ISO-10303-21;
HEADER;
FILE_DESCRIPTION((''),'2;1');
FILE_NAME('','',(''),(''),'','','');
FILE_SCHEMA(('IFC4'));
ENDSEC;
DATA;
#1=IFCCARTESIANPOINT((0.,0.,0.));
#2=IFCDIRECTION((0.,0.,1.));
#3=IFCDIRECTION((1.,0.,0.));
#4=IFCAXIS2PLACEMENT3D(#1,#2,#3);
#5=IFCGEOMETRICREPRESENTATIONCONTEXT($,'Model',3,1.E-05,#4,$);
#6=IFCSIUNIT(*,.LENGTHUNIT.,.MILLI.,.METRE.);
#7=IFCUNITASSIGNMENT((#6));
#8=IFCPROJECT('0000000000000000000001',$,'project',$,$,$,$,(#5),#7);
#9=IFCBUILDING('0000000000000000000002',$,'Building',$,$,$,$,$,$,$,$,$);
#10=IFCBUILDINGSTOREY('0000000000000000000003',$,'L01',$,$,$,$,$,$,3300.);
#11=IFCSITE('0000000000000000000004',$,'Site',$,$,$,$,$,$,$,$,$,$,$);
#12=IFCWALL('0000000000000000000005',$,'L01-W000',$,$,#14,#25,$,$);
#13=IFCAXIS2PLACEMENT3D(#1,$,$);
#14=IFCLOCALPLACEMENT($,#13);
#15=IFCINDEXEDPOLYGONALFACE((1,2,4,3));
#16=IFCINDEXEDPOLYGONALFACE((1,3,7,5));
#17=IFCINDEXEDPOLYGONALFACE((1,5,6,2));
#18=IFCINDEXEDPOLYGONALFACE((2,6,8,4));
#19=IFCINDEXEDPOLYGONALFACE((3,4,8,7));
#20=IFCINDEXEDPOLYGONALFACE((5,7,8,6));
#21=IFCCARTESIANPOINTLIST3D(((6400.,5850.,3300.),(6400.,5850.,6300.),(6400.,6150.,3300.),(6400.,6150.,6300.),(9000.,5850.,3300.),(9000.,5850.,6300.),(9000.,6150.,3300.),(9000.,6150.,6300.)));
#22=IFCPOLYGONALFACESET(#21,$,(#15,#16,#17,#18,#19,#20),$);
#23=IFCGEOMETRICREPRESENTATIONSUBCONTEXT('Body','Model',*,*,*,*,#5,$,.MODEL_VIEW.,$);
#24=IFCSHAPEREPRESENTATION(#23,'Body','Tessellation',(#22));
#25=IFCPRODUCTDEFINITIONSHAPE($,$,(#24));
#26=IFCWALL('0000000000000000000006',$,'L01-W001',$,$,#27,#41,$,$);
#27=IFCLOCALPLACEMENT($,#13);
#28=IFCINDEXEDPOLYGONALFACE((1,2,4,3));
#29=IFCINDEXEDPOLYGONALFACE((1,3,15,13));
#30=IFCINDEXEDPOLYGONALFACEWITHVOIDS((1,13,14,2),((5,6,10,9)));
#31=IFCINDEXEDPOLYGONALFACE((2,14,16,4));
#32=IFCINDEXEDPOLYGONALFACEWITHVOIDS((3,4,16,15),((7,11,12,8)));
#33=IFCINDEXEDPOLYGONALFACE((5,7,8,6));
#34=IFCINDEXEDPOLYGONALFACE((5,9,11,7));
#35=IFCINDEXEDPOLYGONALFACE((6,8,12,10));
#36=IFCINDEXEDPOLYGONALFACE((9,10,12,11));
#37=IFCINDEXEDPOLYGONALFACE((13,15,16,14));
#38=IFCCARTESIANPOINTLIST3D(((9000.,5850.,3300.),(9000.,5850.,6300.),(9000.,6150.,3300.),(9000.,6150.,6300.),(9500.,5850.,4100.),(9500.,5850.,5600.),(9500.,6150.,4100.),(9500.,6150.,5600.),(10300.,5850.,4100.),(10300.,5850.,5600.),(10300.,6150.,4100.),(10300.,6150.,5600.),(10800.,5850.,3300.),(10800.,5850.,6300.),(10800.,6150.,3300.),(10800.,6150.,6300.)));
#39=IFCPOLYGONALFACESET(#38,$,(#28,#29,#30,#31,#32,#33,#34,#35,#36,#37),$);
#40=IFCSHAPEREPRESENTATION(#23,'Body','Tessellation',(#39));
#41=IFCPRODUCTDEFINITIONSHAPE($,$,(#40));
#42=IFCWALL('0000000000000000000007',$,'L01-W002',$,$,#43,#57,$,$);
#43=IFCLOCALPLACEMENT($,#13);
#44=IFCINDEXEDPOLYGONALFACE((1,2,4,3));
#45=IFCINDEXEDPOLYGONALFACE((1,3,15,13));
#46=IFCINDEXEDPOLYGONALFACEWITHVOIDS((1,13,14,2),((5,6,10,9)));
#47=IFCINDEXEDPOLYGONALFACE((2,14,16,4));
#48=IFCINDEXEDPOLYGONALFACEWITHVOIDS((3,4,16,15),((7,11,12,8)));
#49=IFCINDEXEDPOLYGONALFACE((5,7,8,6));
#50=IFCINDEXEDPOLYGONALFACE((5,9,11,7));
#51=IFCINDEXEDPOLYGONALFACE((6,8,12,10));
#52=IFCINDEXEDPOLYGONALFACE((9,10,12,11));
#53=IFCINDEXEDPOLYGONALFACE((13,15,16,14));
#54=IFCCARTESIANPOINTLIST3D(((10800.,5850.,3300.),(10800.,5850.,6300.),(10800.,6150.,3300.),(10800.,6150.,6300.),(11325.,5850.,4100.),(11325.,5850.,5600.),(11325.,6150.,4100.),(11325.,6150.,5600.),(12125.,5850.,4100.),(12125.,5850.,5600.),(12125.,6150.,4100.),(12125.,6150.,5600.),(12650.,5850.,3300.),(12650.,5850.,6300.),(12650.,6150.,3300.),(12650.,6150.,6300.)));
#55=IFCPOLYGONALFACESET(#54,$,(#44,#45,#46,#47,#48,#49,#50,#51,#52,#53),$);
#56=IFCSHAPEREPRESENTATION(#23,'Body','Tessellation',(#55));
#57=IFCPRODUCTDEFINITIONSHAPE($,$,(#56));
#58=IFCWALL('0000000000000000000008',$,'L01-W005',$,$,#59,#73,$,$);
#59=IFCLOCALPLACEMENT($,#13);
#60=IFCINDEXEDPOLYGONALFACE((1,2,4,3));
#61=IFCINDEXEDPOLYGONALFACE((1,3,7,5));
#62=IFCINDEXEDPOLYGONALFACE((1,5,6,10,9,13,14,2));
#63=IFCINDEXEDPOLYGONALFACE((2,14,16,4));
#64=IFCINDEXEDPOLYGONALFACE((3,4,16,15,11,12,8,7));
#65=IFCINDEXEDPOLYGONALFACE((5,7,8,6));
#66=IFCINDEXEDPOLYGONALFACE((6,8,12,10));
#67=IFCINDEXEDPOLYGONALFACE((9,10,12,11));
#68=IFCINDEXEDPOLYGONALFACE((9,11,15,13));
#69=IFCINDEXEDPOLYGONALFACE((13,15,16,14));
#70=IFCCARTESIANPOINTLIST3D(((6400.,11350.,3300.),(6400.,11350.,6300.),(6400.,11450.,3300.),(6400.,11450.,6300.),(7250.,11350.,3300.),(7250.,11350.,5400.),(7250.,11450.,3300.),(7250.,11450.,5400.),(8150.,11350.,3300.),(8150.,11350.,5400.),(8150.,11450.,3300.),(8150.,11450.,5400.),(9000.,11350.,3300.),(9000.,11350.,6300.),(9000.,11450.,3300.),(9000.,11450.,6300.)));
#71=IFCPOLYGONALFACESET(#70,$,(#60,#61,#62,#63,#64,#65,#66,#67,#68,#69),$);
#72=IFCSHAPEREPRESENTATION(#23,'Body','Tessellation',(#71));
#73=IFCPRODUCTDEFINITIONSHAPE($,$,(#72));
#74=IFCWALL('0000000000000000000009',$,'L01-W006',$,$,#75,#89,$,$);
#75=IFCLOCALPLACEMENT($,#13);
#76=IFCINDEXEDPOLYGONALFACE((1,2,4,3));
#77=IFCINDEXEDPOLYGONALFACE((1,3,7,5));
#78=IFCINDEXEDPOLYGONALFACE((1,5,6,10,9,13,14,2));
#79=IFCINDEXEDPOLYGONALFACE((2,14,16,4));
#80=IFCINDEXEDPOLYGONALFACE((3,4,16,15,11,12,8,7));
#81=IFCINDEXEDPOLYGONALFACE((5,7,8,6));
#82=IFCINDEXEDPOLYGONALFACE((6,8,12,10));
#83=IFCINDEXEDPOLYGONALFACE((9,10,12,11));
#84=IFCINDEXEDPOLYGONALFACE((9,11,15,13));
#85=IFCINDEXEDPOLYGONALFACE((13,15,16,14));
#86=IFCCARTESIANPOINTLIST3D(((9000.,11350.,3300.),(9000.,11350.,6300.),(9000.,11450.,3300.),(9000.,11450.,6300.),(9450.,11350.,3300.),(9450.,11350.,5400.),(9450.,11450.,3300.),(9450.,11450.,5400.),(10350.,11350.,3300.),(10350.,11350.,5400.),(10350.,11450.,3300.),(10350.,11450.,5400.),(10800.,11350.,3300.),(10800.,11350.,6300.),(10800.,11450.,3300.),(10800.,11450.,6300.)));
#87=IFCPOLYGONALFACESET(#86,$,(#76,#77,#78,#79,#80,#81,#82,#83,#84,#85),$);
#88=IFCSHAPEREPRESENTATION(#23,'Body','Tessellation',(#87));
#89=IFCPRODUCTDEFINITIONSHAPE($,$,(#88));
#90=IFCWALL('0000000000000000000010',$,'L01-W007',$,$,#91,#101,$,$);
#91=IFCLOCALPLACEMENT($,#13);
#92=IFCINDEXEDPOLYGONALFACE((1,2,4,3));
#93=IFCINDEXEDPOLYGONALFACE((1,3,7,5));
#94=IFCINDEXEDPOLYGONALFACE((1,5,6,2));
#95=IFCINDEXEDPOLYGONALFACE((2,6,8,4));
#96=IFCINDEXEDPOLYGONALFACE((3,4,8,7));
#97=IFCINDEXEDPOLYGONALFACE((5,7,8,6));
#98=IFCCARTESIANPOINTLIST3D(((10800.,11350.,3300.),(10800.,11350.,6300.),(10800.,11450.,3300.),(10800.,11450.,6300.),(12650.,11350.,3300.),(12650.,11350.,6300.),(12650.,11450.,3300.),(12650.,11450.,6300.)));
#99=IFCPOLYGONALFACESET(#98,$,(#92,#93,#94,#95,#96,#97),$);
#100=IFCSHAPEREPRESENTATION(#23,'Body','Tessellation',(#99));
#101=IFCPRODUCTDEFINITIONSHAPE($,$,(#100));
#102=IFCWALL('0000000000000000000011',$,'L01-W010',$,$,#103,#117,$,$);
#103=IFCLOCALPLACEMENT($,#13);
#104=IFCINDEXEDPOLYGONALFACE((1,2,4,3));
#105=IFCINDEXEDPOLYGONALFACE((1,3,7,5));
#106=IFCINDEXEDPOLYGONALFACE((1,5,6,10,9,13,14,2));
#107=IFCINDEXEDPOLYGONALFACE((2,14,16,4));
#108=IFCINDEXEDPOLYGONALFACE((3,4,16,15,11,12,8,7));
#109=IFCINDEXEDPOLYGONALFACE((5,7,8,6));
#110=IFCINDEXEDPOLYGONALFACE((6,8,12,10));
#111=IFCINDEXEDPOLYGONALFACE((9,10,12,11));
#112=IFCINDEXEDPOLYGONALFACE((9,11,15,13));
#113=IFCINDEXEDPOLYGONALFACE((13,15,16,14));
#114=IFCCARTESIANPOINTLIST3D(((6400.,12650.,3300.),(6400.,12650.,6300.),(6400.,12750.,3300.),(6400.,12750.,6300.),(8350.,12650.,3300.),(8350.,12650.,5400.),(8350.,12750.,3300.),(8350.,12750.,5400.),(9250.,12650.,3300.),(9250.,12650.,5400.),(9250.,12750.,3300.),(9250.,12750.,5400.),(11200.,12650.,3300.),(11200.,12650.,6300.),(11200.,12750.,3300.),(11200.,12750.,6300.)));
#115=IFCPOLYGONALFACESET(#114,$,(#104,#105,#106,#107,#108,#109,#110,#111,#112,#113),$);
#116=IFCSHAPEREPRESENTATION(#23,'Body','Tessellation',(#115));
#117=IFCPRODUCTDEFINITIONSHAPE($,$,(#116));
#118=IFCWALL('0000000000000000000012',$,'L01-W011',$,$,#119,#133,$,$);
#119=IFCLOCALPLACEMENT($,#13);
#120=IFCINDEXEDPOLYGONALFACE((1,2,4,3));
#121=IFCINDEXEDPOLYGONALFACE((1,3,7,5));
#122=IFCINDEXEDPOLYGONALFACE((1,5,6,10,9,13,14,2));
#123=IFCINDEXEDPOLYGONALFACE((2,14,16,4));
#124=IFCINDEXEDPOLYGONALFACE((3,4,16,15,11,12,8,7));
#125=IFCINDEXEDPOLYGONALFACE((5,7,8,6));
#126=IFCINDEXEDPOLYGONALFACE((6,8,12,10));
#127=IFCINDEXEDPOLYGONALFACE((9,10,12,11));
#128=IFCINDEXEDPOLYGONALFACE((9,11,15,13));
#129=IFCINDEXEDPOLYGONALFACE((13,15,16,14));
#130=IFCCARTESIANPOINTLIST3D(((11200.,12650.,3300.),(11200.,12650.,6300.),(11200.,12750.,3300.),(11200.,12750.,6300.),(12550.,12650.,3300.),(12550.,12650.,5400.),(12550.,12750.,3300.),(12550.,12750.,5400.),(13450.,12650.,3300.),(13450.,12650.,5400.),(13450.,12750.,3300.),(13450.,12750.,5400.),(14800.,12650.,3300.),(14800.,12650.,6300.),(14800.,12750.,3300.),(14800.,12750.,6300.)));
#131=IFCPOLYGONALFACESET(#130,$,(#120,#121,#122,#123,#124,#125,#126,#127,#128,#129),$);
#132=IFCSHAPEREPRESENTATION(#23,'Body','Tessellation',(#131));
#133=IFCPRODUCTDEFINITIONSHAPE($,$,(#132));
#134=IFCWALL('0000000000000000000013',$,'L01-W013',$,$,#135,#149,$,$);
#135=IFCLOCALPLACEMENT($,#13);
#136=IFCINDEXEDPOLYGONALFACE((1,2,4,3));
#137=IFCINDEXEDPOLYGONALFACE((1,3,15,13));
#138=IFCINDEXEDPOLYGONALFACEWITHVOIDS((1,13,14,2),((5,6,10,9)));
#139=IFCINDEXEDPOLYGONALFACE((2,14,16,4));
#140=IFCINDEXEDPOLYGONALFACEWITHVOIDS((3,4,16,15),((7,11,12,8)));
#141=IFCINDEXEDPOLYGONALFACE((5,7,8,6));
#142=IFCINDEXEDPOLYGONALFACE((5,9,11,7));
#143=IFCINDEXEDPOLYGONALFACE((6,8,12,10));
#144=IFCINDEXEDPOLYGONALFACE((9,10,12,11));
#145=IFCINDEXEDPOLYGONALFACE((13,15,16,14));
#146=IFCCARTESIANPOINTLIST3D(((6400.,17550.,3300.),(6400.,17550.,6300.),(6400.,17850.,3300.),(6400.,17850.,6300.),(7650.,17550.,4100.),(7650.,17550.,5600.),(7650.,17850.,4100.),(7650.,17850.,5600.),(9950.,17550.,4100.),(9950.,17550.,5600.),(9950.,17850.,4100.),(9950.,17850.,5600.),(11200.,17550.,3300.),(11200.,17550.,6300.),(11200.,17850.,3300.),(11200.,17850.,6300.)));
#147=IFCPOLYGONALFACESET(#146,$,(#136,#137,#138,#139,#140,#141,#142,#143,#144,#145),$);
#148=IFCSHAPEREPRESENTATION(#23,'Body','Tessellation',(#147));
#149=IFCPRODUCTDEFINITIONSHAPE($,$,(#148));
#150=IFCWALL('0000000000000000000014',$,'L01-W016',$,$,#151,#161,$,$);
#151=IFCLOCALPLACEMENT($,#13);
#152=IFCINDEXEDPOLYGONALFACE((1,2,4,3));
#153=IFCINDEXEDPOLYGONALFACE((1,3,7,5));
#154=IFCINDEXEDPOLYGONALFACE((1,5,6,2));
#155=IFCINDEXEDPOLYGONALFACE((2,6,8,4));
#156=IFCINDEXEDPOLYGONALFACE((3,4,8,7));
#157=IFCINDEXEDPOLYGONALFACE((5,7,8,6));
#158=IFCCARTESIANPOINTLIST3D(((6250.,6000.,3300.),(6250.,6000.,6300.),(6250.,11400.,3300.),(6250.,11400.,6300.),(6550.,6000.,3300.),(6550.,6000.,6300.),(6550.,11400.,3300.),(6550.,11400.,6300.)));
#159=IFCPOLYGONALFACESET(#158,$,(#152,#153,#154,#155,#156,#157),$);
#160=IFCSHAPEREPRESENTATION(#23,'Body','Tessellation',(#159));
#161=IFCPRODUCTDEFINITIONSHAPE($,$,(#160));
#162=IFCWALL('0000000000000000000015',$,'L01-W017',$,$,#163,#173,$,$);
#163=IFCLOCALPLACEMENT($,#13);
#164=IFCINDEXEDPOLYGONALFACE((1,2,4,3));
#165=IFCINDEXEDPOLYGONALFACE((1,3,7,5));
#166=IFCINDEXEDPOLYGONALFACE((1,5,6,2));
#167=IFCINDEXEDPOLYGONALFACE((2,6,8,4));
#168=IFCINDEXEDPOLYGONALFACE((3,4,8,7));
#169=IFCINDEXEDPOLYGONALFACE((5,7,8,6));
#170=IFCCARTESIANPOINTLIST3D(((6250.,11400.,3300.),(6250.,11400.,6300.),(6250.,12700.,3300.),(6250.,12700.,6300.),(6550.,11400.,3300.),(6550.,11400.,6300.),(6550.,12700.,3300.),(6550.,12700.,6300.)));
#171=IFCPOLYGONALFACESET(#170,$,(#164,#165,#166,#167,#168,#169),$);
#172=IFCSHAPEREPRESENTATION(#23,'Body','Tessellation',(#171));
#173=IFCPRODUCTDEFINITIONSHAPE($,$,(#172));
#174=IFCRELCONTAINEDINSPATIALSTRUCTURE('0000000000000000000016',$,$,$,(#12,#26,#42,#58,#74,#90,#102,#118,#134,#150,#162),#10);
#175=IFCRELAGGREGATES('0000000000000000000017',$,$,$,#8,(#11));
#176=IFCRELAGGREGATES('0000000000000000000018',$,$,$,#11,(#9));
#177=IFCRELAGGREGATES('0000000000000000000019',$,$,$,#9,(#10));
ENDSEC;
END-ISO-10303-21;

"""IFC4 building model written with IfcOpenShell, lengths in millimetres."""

from ifc_helpers import new_model, si_unit, frame, origin_with_axes, place, context, subcontext, project, spatial, indexed_curve, outline, extrude, element, save


model = new_model("IFC4")

# Units and contexts
model_context = context("Model", 3, precision=1e-05, world=origin_with_axes())
body_context = subcontext(model_context, "Body", "Model", "MODEL_VIEW")
ifc_project = project(units=[si_unit("LENGTHUNIT", "METRE", prefix="MILLI")], contexts=[model_context])

# Site, building, storey
site = spatial("IfcSite", under=ifc_project, Name="Site")
building = spatial("IfcBuilding", under=site, Name="Building")
storey = spatial("IfcBuildingStorey", under=building, Name="L01", Elevation=3300.0)

# Wall
wall_1_placement = place(None, frame((6400.0, 5850.0, 3300.0), z_axis=(0.0, 0.0, 1.0), x_axis=(1.0, 0.0, 0.0)))
element("IfcWall", 1, at=wall_1_placement, inside=storey, Name="L01-W000", context=body_context, shape_type="SweptSolid", body=[
    extrude(outline(indexed_curve([(0.0, 0.0), (0.0, 300.0), (2600.0, 300.0), (2600.0, 0.0), (0.0, 0.0)], self_intersect=False)), origin_with_axes(), (0.0, 0.0, 1.0), 3000.0),
])

# Walls, openings
wall_2_placement = place(None, frame((9000.0, 5850.0, 3300.0), z_axis=(0.0, 0.0, 1.0), x_axis=(1.0, 0.0, 0.0)))
wall_2 = element("IfcWall", 2, at=wall_2_placement, inside=storey, Name="L01-W001", context=body_context, shape_type="SweptSolid", body=[
    extrude(outline(indexed_curve([(0.0, 0.0), (0.0, 300.0), (1800.0, 300.0), (1800.0, 0.0), (0.0, 0.0)], self_intersect=False)), origin_with_axes(), (0.0, 0.0, 1.0), 3000.0),
])
opening_1_placement = place(wall_2_placement, frame((500.0, -10.0, 800.0), z_axis=(0.0, 0.0, 1.0), x_axis=(1.0, 0.0, 0.0)))
element("IfcOpeningElement", 3, at=opening_1_placement, cuts=wall_2, context=body_context, shape_type="SweptSolid", body=[
    extrude(outline(indexed_curve([(0.0, 0.0), (0.0, 320.0), (800.0, 320.0), (800.0, 0.0), (0.0, 0.0)], self_intersect=False)), origin_with_axes(), (0.0, 0.0, 1.0), 1500.0),
])
wall_3_placement = place(None, frame((10800.0, 5850.0, 3300.0), z_axis=(0.0, 0.0, 1.0), x_axis=(1.0, 0.0, 0.0)))
wall_3 = element("IfcWall", 4, at=wall_3_placement, inside=storey, Name="L01-W002", context=body_context, shape_type="SweptSolid", body=[
    extrude(outline(indexed_curve([(0.0, 0.0), (0.0, 300.0), (1850.0, 300.0), (1850.0, 0.0), (0.0, 0.0)], self_intersect=False)), origin_with_axes(), (0.0, 0.0, 1.0), 3000.0),
])
opening_2_placement = place(wall_3_placement, frame((525.0, -10.0, 800.0), z_axis=(0.0, 0.0, 1.0), x_axis=(1.0, 0.0, 0.0)))
element("IfcOpeningElement", 5, at=opening_2_placement, cuts=wall_3, context=body_context, shape_type="SweptSolid", body=[
    extrude(outline(indexed_curve([(0.0, 0.0), (0.0, 320.0), (800.0, 320.0), (800.0, 0.0), (0.0, 0.0)], self_intersect=False)), origin_with_axes(), (0.0, 0.0, 1.0), 1500.0),
])
wall_4_placement = place(None, frame((6400.0, 11350.0, 3300.0), z_axis=(0.0, 0.0, 1.0), x_axis=(1.0, 0.0, 0.0)))
wall_4 = element("IfcWall", 6, at=wall_4_placement, inside=storey, Name="L01-W005", context=body_context, shape_type="SweptSolid", body=[
    extrude(outline(indexed_curve([(0.0, 0.0), (0.0, 100.0), (2600.0, 100.0), (2600.0, 0.0), (0.0, 0.0)], self_intersect=False)), origin_with_axes(), (0.0, 0.0, 1.0), 3000.0),
])
opening_3_placement = place(wall_4_placement, frame((850.0, -10.0, 0.0), z_axis=(0.0, 0.0, 1.0), x_axis=(1.0, 0.0, 0.0)))
element("IfcOpeningElement", 7, at=opening_3_placement, cuts=wall_4, context=body_context, shape_type="SweptSolid", body=[
    extrude(outline(indexed_curve([(0.0, 0.0), (0.0, 120.0), (900.0, 120.0), (900.0, 0.0), (0.0, 0.0)], self_intersect=False)), origin_with_axes(), (0.0, 0.0, 1.0), 2100.0),
])
wall_5_placement = place(None, frame((9000.0, 11350.0, 3300.0), z_axis=(0.0, 0.0, 1.0), x_axis=(1.0, 0.0, 0.0)))
wall_5 = element("IfcWall", 8, at=wall_5_placement, inside=storey, Name="L01-W006", context=body_context, shape_type="SweptSolid", body=[
    extrude(outline(indexed_curve([(0.0, 0.0), (0.0, 100.0), (1800.0, 100.0), (1800.0, 0.0), (0.0, 0.0)], self_intersect=False)), origin_with_axes(), (0.0, 0.0, 1.0), 3000.0),
])
opening_4_placement = place(wall_5_placement, frame((450.0, -10.0, 0.0), z_axis=(0.0, 0.0, 1.0), x_axis=(1.0, 0.0, 0.0)))
element("IfcOpeningElement", 9, at=opening_4_placement, cuts=wall_5, context=body_context, shape_type="SweptSolid", body=[
    extrude(outline(indexed_curve([(0.0, 0.0), (0.0, 120.0), (900.0, 120.0), (900.0, 0.0), (0.0, 0.0)], self_intersect=False)), origin_with_axes(), (0.0, 0.0, 1.0), 2100.0),
])

# Wall
wall_6_placement = place(None, frame((10800.0, 11350.0, 3300.0), z_axis=(0.0, 0.0, 1.0), x_axis=(1.0, 0.0, 0.0)))
element("IfcWall", 10, at=wall_6_placement, inside=storey, Name="L01-W007", context=body_context, shape_type="SweptSolid", body=[
    extrude(outline(indexed_curve([(0.0, 0.0), (0.0, 100.0), (1850.0, 100.0), (1850.0, 0.0), (0.0, 0.0)], self_intersect=False)), origin_with_axes(), (0.0, 0.0, 1.0), 3000.0),
])

# Walls, openings
wall_7_placement = place(None, frame((6400.0, 12650.0, 3300.0), z_axis=(0.0, 0.0, 1.0), x_axis=(1.0, 0.0, 0.0)))
wall_7 = element("IfcWall", 11, at=wall_7_placement, inside=storey, Name="L01-W010", context=body_context, shape_type="SweptSolid", body=[
    extrude(outline(indexed_curve([(0.0, 0.0), (0.0, 100.0), (4800.0, 100.0), (4800.0, 0.0), (0.0, 0.0)], self_intersect=False)), origin_with_axes(), (0.0, 0.0, 1.0), 3000.0),
])
opening_5_placement = place(wall_7_placement, frame((1950.0, -10.0, 0.0), z_axis=(0.0, 0.0, 1.0), x_axis=(1.0, 0.0, 0.0)))
element("IfcOpeningElement", 12, at=opening_5_placement, cuts=wall_7, context=body_context, shape_type="SweptSolid", body=[
    extrude(outline(indexed_curve([(0.0, 0.0), (0.0, 120.0), (900.0, 120.0), (900.0, 0.0), (0.0, 0.0)], self_intersect=False)), origin_with_axes(), (0.0, 0.0, 1.0), 2100.0),
])
wall_8_placement = place(None, frame((11200.0, 12650.0, 3300.0), z_axis=(0.0, 0.0, 1.0), x_axis=(1.0, 0.0, 0.0)))
wall_8 = element("IfcWall", 13, at=wall_8_placement, inside=storey, Name="L01-W011", context=body_context, shape_type="SweptSolid", body=[
    extrude(outline(indexed_curve([(0.0, 0.0), (0.0, 100.0), (3600.0, 100.0), (3600.0, 0.0), (0.0, 0.0)], self_intersect=False)), origin_with_axes(), (0.0, 0.0, 1.0), 3000.0),
])
opening_6_placement = place(wall_8_placement, frame((1350.0, -10.0, 0.0), z_axis=(0.0, 0.0, 1.0), x_axis=(1.0, 0.0, 0.0)))
element("IfcOpeningElement", 14, at=opening_6_placement, cuts=wall_8, context=body_context, shape_type="SweptSolid", body=[
    extrude(outline(indexed_curve([(0.0, 0.0), (0.0, 120.0), (900.0, 120.0), (900.0, 0.0), (0.0, 0.0)], self_intersect=False)), origin_with_axes(), (0.0, 0.0, 1.0), 2100.0),
])
wall_9_placement = place(None, frame((6400.0, 17550.0, 3300.0), z_axis=(0.0, 0.0, 1.0), x_axis=(1.0, 0.0, 0.0)))
wall_9 = element("IfcWall", 15, at=wall_9_placement, inside=storey, Name="L01-W013", context=body_context, shape_type="SweptSolid", body=[
    extrude(outline(indexed_curve([(0.0, 0.0), (0.0, 300.0), (4800.0, 300.0), (4800.0, 0.0), (0.0, 0.0)], self_intersect=False)), origin_with_axes(), (0.0, 0.0, 1.0), 3000.0),
])
opening_7_placement = place(wall_9_placement, frame((1250.0, -10.0, 800.0), z_axis=(0.0, 0.0, 1.0), x_axis=(1.0, 0.0, 0.0)))
element("IfcOpeningElement", 16, at=opening_7_placement, cuts=wall_9, context=body_context, shape_type="SweptSolid", body=[
    extrude(outline(indexed_curve([(0.0, 0.0), (0.0, 320.0), (2300.0, 320.0), (2300.0, 0.0), (0.0, 0.0)], self_intersect=False)), origin_with_axes(), (0.0, 0.0, 1.0), 1500.0),
])

# Walls
wall_10_placement = place(None, frame((6550.0, 6000.0, 3300.0), z_axis=(0.0, 0.0, 1.0), x_axis=(0.0, 1.0, 0.0)))
element("IfcWall", 17, at=wall_10_placement, inside=storey, Name="L01-W016", context=body_context, shape_type="SweptSolid", body=[
    extrude(outline(indexed_curve([(0.0, 0.0), (0.0, 300.0), (5400.0, 300.0), (5400.0, 0.0), (0.0, 0.0)], self_intersect=False)), origin_with_axes(), (0.0, 0.0, 1.0), 3000.0),
])
wall_11_placement = place(None, frame((6550.0, 11400.0, 3300.0), z_axis=(0.0, 0.0, 1.0), x_axis=(0.0, 1.0, 0.0)))
element("IfcWall", 18, at=wall_11_placement, inside=storey, Name="L01-W017", context=body_context, shape_type="SweptSolid", body=[
    extrude(outline(indexed_curve([(0.0, 0.0), (0.0, 300.0), (1300.0, 300.0), (1300.0, 0.0), (0.0, 0.0)], self_intersect=False)), origin_with_axes(), (0.0, 0.0, 1.0), 3000.0),
])

save(model, "model.ifc")
